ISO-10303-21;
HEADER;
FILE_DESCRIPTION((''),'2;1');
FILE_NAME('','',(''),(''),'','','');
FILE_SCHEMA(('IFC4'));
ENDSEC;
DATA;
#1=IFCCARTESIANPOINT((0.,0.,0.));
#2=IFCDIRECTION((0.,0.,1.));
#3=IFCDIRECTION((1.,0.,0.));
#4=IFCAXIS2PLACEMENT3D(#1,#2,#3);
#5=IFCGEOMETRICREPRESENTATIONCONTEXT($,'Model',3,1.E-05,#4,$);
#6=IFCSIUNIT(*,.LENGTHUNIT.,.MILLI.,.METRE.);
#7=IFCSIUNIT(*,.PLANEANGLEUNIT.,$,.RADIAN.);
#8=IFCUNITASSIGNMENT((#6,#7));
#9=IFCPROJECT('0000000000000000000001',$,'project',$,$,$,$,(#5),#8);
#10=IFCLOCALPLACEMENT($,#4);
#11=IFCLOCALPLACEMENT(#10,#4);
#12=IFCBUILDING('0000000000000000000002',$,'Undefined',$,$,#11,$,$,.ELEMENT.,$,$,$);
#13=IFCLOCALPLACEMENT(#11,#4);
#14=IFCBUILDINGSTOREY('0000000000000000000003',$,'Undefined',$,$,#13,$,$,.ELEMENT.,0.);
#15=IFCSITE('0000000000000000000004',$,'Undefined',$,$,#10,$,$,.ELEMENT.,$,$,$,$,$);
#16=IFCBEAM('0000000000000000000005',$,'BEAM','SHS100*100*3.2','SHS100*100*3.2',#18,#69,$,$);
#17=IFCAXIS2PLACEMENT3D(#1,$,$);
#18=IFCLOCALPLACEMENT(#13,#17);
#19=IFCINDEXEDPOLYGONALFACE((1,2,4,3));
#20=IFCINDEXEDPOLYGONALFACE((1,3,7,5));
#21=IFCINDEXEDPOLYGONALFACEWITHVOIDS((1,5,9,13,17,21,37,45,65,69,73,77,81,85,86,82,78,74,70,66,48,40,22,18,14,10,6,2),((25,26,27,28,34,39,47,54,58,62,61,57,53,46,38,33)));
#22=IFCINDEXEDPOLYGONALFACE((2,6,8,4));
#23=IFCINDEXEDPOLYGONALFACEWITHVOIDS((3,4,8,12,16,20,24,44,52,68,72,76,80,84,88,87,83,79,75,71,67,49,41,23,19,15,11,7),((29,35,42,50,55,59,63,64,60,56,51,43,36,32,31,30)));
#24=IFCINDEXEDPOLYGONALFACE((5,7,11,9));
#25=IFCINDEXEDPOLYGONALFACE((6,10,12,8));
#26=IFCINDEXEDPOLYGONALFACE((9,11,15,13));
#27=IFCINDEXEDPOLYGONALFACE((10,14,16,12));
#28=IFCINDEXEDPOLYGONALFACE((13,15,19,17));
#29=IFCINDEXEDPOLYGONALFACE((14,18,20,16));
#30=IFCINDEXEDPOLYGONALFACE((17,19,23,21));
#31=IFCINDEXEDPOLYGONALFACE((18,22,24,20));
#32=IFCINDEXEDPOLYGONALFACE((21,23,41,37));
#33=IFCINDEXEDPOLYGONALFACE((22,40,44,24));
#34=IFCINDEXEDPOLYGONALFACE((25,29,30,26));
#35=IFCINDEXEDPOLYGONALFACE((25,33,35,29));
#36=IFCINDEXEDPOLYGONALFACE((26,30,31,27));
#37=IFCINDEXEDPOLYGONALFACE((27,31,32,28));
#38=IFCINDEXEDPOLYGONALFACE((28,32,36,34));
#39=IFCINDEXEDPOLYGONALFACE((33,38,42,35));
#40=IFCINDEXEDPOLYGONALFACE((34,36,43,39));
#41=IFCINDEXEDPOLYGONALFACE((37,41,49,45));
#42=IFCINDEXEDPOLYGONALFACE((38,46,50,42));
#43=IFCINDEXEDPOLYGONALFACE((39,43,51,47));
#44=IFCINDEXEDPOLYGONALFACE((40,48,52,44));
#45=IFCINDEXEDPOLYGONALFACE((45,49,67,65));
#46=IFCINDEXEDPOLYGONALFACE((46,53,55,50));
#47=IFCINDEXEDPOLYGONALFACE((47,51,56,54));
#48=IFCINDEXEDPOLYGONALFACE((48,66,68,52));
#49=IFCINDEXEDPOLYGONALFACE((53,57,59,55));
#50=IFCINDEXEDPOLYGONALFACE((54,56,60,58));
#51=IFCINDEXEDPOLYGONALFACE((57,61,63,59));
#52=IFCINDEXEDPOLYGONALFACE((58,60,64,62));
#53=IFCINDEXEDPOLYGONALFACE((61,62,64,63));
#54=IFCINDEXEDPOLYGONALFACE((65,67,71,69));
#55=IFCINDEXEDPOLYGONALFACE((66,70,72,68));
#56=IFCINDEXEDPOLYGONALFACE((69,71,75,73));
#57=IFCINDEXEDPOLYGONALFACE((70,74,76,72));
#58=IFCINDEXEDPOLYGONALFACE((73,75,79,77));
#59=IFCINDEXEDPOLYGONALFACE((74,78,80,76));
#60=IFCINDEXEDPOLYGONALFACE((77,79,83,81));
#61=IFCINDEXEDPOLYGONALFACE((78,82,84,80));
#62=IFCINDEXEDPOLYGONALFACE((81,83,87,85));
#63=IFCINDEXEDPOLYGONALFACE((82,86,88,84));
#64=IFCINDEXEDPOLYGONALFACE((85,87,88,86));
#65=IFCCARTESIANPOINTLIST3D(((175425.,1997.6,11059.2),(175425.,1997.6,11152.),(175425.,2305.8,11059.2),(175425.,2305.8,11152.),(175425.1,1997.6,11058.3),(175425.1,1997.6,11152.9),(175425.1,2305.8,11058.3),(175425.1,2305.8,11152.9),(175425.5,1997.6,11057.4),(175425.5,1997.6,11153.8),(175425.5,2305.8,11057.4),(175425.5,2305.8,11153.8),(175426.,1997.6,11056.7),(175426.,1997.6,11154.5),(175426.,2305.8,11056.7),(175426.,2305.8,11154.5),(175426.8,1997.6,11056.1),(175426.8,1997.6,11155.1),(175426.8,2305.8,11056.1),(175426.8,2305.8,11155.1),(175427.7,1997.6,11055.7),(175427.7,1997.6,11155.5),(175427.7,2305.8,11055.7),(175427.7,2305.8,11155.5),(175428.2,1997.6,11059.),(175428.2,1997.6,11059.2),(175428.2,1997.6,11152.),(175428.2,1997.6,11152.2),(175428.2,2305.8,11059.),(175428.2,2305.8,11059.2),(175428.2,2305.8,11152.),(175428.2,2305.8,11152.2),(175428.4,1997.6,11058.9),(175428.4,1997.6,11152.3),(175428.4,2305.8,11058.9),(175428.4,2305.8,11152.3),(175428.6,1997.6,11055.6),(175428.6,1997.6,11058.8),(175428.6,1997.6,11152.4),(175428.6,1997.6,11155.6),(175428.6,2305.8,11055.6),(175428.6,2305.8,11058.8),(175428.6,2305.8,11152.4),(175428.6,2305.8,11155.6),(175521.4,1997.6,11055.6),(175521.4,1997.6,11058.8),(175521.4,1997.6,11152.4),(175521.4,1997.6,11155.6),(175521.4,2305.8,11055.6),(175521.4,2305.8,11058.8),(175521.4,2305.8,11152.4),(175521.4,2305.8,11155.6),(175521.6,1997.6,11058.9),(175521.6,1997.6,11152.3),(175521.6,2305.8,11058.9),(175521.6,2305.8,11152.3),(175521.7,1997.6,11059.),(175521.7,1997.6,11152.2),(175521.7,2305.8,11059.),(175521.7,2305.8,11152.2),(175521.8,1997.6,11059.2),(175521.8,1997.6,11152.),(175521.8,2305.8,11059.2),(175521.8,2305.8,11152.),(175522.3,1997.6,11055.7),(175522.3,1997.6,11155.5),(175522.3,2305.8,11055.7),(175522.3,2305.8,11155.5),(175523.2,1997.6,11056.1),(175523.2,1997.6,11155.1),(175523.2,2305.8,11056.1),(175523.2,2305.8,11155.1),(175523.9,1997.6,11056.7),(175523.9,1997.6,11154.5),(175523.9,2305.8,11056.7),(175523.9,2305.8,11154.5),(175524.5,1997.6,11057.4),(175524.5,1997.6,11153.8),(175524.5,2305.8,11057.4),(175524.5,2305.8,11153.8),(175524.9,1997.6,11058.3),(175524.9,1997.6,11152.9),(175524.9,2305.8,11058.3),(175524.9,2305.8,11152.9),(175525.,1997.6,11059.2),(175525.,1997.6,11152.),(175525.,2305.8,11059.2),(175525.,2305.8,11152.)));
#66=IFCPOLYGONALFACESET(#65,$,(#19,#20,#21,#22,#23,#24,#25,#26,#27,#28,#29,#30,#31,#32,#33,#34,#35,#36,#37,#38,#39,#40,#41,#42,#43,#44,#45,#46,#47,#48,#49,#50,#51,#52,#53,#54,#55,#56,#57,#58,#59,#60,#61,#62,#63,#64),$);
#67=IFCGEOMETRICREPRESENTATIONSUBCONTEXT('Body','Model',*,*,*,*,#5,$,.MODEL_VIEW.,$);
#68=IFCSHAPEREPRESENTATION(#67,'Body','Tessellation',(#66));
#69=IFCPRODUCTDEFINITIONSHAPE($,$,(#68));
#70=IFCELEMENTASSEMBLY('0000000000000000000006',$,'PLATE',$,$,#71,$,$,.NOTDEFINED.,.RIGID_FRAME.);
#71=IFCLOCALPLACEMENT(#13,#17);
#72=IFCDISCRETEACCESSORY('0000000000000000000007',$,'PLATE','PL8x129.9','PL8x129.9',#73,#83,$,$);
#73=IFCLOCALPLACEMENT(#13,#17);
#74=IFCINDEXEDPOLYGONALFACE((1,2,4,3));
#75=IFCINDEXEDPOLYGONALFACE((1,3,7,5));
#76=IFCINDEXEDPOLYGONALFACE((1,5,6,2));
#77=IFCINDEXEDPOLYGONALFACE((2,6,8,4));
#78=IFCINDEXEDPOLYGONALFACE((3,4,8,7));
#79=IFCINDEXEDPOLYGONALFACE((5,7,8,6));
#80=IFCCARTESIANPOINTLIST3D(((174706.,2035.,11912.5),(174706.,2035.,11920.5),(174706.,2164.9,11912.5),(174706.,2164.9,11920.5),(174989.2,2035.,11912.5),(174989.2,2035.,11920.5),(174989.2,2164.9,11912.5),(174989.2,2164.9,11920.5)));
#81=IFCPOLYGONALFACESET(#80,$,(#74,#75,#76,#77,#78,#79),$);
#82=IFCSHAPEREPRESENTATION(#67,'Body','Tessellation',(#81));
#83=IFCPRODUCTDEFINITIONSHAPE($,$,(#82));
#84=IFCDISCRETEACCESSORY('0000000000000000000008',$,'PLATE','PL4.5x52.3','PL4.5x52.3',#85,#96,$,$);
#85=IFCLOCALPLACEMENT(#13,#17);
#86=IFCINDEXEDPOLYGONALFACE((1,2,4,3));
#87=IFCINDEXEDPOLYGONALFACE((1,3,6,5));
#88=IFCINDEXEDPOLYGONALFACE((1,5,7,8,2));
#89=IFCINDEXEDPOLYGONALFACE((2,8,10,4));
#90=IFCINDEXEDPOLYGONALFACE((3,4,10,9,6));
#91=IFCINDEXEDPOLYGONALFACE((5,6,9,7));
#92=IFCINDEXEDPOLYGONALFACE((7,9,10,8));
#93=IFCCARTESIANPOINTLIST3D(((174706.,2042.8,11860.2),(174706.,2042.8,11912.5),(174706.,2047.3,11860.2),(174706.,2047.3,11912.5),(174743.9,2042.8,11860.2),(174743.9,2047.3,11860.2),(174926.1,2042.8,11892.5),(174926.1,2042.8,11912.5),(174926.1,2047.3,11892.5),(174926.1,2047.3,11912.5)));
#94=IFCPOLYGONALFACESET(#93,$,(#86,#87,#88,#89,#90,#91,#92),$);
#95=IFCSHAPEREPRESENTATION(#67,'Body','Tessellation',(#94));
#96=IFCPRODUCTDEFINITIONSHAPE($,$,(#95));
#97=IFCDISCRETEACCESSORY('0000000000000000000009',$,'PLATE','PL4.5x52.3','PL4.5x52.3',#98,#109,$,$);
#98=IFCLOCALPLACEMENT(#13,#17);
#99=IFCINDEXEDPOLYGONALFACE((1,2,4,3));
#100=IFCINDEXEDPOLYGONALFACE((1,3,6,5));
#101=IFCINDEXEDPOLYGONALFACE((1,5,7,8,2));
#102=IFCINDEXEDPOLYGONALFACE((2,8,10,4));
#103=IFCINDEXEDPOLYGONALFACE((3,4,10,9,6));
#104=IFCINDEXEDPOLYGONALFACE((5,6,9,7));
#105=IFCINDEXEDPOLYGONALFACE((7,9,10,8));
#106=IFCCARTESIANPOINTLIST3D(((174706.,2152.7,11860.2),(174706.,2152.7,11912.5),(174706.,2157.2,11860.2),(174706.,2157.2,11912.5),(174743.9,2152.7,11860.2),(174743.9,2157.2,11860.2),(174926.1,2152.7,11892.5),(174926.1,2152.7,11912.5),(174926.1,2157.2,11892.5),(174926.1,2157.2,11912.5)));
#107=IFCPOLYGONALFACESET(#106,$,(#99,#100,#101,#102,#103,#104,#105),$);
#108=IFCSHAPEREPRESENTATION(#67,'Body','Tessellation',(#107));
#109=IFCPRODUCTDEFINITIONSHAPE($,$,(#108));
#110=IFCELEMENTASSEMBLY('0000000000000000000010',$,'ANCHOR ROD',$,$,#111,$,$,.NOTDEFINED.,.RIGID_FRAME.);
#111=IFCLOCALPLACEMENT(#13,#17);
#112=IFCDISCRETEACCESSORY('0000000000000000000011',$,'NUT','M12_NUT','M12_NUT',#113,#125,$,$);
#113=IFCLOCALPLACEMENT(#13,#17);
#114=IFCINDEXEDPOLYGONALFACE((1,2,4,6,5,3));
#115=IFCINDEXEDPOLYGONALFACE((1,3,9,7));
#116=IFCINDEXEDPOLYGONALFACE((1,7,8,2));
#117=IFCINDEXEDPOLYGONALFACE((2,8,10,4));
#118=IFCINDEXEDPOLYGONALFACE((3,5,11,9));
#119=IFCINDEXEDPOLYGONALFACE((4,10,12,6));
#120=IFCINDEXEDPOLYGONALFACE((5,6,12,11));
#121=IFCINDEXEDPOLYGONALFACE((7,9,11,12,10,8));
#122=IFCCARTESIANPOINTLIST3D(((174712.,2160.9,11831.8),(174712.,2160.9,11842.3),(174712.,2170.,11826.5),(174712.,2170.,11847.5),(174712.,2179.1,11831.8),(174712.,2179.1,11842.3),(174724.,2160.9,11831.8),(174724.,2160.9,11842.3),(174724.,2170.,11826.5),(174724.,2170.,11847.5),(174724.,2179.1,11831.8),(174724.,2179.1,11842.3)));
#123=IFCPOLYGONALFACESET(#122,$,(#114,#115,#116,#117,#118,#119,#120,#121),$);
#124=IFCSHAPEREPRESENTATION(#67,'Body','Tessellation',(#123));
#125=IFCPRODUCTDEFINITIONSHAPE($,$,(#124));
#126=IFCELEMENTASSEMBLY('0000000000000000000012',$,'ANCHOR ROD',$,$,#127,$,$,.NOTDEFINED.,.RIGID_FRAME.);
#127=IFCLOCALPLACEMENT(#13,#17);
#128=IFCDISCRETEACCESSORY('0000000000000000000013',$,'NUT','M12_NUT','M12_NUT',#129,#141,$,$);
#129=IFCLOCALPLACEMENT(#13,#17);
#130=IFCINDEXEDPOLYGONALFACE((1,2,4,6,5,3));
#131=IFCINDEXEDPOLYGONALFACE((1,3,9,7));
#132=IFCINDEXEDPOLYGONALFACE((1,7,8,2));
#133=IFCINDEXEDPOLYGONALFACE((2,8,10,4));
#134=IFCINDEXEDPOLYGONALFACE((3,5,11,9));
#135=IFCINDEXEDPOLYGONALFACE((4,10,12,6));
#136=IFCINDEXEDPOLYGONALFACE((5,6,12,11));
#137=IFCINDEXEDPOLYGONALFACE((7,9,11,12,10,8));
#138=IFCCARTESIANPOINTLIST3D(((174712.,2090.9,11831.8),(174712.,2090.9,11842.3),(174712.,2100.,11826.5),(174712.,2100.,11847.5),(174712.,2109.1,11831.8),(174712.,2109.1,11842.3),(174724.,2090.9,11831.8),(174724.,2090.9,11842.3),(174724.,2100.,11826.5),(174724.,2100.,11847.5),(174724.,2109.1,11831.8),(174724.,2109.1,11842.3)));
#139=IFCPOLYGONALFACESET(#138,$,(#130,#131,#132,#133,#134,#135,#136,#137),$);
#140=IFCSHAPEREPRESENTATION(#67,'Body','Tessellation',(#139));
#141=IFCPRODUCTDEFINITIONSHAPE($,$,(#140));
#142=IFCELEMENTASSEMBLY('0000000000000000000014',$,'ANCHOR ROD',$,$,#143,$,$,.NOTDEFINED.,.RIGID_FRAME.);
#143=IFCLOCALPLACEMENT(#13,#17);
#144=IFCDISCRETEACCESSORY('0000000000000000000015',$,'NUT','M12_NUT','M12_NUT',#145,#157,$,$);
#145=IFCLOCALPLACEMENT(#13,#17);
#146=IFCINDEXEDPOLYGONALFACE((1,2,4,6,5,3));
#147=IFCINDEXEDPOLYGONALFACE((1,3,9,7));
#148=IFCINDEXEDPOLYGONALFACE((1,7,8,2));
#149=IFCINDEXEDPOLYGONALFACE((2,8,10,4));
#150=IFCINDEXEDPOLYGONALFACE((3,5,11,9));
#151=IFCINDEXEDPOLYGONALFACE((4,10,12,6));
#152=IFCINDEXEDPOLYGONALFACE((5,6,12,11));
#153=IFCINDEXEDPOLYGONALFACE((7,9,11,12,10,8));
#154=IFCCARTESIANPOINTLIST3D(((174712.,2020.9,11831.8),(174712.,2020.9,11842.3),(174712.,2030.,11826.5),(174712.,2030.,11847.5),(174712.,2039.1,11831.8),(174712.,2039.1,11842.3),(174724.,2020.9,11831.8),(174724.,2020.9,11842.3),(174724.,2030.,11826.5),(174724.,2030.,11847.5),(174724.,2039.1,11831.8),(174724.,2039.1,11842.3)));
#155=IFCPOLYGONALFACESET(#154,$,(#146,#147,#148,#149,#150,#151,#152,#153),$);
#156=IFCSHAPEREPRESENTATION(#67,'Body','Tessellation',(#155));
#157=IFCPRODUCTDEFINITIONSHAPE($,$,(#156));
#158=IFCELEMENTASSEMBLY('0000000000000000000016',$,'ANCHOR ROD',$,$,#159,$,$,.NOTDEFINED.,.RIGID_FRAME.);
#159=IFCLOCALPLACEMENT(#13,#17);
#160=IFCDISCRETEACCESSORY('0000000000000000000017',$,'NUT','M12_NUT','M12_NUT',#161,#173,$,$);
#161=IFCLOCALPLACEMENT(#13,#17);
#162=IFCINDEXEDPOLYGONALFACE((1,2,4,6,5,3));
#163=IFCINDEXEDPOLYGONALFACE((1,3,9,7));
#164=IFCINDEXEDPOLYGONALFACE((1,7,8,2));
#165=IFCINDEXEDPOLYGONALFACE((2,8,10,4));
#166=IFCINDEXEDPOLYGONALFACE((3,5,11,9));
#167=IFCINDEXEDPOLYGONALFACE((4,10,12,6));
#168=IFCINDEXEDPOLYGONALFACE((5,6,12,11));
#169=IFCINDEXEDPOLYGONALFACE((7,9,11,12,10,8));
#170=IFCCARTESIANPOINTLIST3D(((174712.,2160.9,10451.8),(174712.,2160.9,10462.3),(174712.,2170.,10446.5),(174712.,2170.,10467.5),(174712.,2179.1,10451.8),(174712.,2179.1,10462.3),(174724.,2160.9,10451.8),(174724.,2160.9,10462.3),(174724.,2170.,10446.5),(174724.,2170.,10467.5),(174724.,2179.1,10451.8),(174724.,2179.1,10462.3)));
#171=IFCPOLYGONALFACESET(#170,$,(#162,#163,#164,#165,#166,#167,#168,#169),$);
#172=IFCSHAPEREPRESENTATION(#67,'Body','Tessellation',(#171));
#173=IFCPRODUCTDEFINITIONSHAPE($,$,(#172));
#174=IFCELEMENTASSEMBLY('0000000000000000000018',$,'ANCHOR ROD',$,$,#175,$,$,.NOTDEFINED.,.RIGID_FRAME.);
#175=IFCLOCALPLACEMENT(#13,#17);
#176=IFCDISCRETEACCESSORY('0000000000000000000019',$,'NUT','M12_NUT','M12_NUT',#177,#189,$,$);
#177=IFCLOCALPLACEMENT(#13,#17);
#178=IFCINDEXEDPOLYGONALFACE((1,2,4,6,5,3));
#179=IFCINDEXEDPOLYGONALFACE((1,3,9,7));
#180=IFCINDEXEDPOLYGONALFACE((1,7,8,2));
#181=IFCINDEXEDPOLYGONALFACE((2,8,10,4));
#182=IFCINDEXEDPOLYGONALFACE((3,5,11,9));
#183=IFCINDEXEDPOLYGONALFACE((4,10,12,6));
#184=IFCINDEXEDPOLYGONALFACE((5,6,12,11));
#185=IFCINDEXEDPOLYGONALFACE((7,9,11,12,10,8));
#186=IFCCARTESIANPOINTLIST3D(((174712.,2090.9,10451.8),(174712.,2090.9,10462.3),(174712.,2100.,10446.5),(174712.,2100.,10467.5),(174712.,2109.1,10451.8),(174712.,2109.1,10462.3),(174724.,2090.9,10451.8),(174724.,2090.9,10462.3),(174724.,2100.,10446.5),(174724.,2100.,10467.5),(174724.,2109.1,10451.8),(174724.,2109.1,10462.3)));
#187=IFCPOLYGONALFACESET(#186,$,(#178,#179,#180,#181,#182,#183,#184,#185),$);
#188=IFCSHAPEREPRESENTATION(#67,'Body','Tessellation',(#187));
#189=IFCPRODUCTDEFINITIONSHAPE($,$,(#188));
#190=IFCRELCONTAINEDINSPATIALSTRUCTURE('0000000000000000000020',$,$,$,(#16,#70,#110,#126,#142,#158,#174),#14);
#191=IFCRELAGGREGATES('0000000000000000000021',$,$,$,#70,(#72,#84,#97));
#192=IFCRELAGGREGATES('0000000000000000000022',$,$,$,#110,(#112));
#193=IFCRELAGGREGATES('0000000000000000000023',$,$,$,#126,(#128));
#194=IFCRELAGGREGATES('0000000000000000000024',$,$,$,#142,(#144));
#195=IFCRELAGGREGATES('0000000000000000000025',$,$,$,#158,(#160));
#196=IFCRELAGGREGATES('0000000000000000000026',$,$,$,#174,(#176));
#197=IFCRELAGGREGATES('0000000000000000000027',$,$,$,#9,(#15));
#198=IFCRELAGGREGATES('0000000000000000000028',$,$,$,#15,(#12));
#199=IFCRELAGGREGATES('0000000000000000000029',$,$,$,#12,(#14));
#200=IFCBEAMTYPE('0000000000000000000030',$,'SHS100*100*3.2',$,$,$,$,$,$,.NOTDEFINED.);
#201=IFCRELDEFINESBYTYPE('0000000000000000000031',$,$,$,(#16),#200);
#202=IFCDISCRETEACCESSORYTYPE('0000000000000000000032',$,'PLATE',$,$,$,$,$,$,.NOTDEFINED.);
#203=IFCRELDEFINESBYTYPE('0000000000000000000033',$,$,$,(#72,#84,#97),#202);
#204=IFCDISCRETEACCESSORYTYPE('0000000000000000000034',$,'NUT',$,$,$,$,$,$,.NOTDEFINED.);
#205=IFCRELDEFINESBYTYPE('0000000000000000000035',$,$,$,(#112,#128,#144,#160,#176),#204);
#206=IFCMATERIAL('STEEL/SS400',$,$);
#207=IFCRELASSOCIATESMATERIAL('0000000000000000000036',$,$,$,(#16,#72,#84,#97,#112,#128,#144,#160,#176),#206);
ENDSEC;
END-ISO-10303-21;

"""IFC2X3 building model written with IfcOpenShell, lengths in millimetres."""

from ifc_helpers import new_model, si_unit, frame, origin_with_axes, origin_2d_with_axis, place, context, subcontext, project, spatial, polyline, hollow_rectangle, outline, extrude, material, type_object, element, aggregate, save


model = new_model("IFC2X3")

# Units and contexts
model_context = context("Model", 3, precision=1e-05, world=origin_with_axes())
body_context = subcontext(model_context, "Body", "Model", "MODEL_VIEW")
ifc_project = project(units=[si_unit("LENGTHUNIT", "METRE", prefix="MILLI"), si_unit("PLANEANGLEUNIT", "RADIAN")], contexts=[model_context])

# Site, building, storey
site_placement = place(None, origin_with_axes())
site = spatial("IfcSite", under=ifc_project, at=site_placement, Name="Undefined", CompositionType="ELEMENT")
building_placement = place(site_placement, origin_with_axes())
building = spatial("IfcBuilding", under=site, at=building_placement, Name="Undefined", CompositionType="ELEMENT")
storey_placement = place(building_placement, origin_with_axes())
storey = spatial("IfcBuildingStorey", under=building, at=storey_placement, Name="Undefined", CompositionType="ELEMENT", Elevation=0.0)

# Beam
ifc_material_1 = material(Name="STEEL/SS400")
beam_type = type_object("IfcBeamType", Name="SHS100*100*3.2", PredefinedType="NOTDEFINED")
beam_placement = place(storey_placement, frame((175475.0, 1997.6, 11105.6), z_axis=(1.0, 0.0, 0.0), x_axis=(0.0, 1.0, 0.0)))
element("IfcBeam", 1, at=beam_placement, inside=storey, type_object=beam_type, material=ifc_material_1, Name="BEAM", Description="SHS100*100*3.2", ObjectType="SHS100*100*3.2", context=body_context, shape_type="SweptSolid", body=[
    extrude(hollow_rectangle(XDim=100.0, YDim=100.0, WallThickness=3.2, InnerFilletRadius=0.4, OuterFilletRadius=3.6, at=origin_2d_with_axis()), frame((308.2, 0.0, 0.0), z_axis=(-1.0, 0.0, 0.0), x_axis=(0.0, -1.0, 0.0)), (0.0, 0.0, 1.0), 308.2),
])

# Element assembly, discrete accessories
assembly_1_placement = place(storey_placement, origin_with_axes())
assembly_1 = element("IfcElementAssembly", 2, at=assembly_1_placement, inside=storey, Name="PLATE", AssemblyPlace="NOTDEFINED", PredefinedType="RIGID_FRAME")
discrete_accessory_type_1 = type_object("IfcDiscreteAccessoryType", Name="PLATE")
discrete_accessory_1_placement = place(assembly_1_placement, frame((174989.2, 2035.0, 11916.5), z_axis=(0.0, 0.0, -1.0), x_axis=(-1.0, 0.0, 0.0)))
discrete_accessory_1 = element("IfcDiscreteAccessory", 3, at=discrete_accessory_1_placement, type_object=discrete_accessory_type_1, material=ifc_material_1, Name="PLATE", Description="PL8x129.9", ObjectType="PL8x129.9", context=body_context, shape_type="SweptSolid", body=[
    extrude(outline(polyline([(0.0, 0.0), (283.2, 0.0), (283.2, 129.9), (0.0, 129.9), (0.0, 0.0)])), frame((0.0, 0.0, -4.0), z_axis=(0.0, 0.0, 1.0), x_axis=(1.0, 0.0, 0.0)), (0.0, 0.0, 1.0), 8.0),
])
discrete_accessory_2_placement = place(assembly_1_placement, frame((174926.1, 2045.0, 11912.5), z_axis=(0.0, 1.0, 0.0), x_axis=(0.0, 0.0, -1.0)))
discrete_accessory_2 = element("IfcDiscreteAccessory", 4, at=discrete_accessory_2_placement, type_object=discrete_accessory_type_1, material=ifc_material_1, Name="PLATE", Description="PL4.5x52.3", ObjectType="PL4.5x52.3", context=body_context, shape_type="SweptSolid", body=[
    extrude(outline(polyline([(0.0, 0.0), (20.0, 0.0), (52.3, 182.2), (52.3, 220.1), (0.0, 220.1), (0.0, 0.0)])), frame((0.0, 0.0, -2.2), z_axis=(0.0, 0.0, 1.0), x_axis=(1.0, 0.0, 0.0)), (0.0, 0.0, 1.0), 4.5),
])
discrete_accessory_3_placement = place(assembly_1_placement, frame((174926.1, 2155.0, 11912.5), z_axis=(0.0, 1.0, 0.0), x_axis=(0.0, 0.0, -1.0)))
discrete_accessory_3 = element("IfcDiscreteAccessory", 5, at=discrete_accessory_3_placement, type_object=discrete_accessory_type_1, material=ifc_material_1, Name="PLATE", Description="PL4.5x52.3", ObjectType="PL4.5x52.3", context=body_context, shape_type="SweptSolid", body=[
    extrude(outline(polyline([(0.0, 0.0), (20.0, 0.0), (52.3, 182.2), (52.3, 220.1), (0.0, 220.1), (0.0, 0.0)])), frame((0.0, 0.0, -2.2), z_axis=(0.0, 0.0, 1.0), x_axis=(1.0, 0.0, 0.0)), (0.0, 0.0, 1.0), 4.5),
])
aggregate(assembly_1, [discrete_accessory_1, discrete_accessory_2, discrete_accessory_3])

# Element assemblies, discrete accessories
assembly_2_placement = place(storey_placement, origin_with_axes())
assembly_2 = element("IfcElementAssembly", 6, at=assembly_2_placement, inside=storey, Name="ANCHOR ROD", AssemblyPlace="NOTDEFINED", PredefinedType="RIGID_FRAME")
discrete_accessory_type_2 = type_object("IfcDiscreteAccessoryType", Name="NUT")
discrete_accessory_4_placement = place(assembly_2_placement, frame((174724.0, 2170.0, 11837.0), z_axis=(0.0, -1.0, 0.0), x_axis=(-1.0, 0.0, 0.0)))
discrete_accessory_4 = element("IfcDiscreteAccessory", 7, at=discrete_accessory_4_placement, type_object=discrete_accessory_type_2, material=ifc_material_1, Name="NUT", Description="M12_NUT", ObjectType="M12_NUT", context=body_context, shape_type="SweptSolid", body=[
    extrude(outline(polyline([(-5.2, -9.1), (-10.5, 0.0), (-5.2, 9.1), (5.3, 9.1), (10.5, 0.0), (5.3, -9.1), (-5.2, -9.1)])), frame((12.0, 0.0, 0.0), z_axis=(-1.0, 0.0, 0.0), x_axis=(0.0, -1.0, 0.0)), (0.0, 0.0, 1.0), 12.0),
])
assembly_3_placement = place(storey_placement, origin_with_axes())
assembly_3 = element("IfcElementAssembly", 8, at=assembly_3_placement, inside=storey, Name="ANCHOR ROD", AssemblyPlace="NOTDEFINED", PredefinedType="RIGID_FRAME")
discrete_accessory_5_placement = place(assembly_3_placement, frame((174724.0, 2100.0, 11837.0), z_axis=(0.0, -1.0, 0.0), x_axis=(-1.0, 0.0, 0.0)))
discrete_accessory_5 = element("IfcDiscreteAccessory", 9, at=discrete_accessory_5_placement, type_object=discrete_accessory_type_2, material=ifc_material_1, Name="NUT", Description="M12_NUT", ObjectType="M12_NUT", context=body_context, shape_type="SweptSolid", body=[
    extrude(outline(polyline([(-5.2, -9.1), (-10.5, 0.0), (-5.2, 9.1), (5.3, 9.1), (10.5, 0.0), (5.3, -9.1), (-5.2, -9.1)])), frame((12.0, 0.0, 0.0), z_axis=(-1.0, 0.0, 0.0), x_axis=(0.0, -1.0, 0.0)), (0.0, 0.0, 1.0), 12.0),
])
assembly_4_placement = place(storey_placement, origin_with_axes())
assembly_4 = element("IfcElementAssembly", 10, at=assembly_4_placement, inside=storey, Name="ANCHOR ROD", AssemblyPlace="NOTDEFINED", PredefinedType="RIGID_FRAME")
discrete_accessory_6_placement = place(assembly_4_placement, frame((174724.0, 2030.0, 11837.0), z_axis=(0.0, -1.0, 0.0), x_axis=(-1.0, 0.0, 0.0)))
discrete_accessory_6 = element("IfcDiscreteAccessory", 11, at=discrete_accessory_6_placement, type_object=discrete_accessory_type_2, material=ifc_material_1, Name="NUT", Description="M12_NUT", ObjectType="M12_NUT", context=body_context, shape_type="SweptSolid", body=[
    extrude(outline(polyline([(-5.2, -9.1), (-10.5, 0.0), (-5.2, 9.1), (5.3, 9.1), (10.5, 0.0), (5.3, -9.1), (-5.2, -9.1)])), frame((12.0, 0.0, 0.0), z_axis=(-1.0, 0.0, 0.0), x_axis=(0.0, -1.0, 0.0)), (0.0, 0.0, 1.0), 12.0),
])
assembly_5_placement = place(storey_placement, origin_with_axes())
assembly_5 = element("IfcElementAssembly", 12, at=assembly_5_placement, inside=storey, Name="ANCHOR ROD", AssemblyPlace="NOTDEFINED", PredefinedType="RIGID_FRAME")
discrete_accessory_7_placement = place(assembly_5_placement, frame((174724.0, 2170.0, 10457.0), z_axis=(0.0, 1.0, 0.0), x_axis=(-1.0, 0.0, 0.0)))
discrete_accessory_7 = element("IfcDiscreteAccessory", 13, at=discrete_accessory_7_placement, type_object=discrete_accessory_type_2, material=ifc_material_1, Name="NUT", Description="M12_NUT", ObjectType="M12_NUT", context=body_context, shape_type="SweptSolid", body=[
    extrude(outline(polyline([(-5.2, -9.1), (-10.5, 0.0), (-5.2, 9.1), (5.3, 9.1), (10.5, 0.0), (5.3, -9.1), (-5.2, -9.1)])), frame((12.0, 0.0, 0.0), z_axis=(-1.0, 0.0, 0.0), x_axis=(0.0, -1.0, 0.0)), (0.0, 0.0, 1.0), 12.0),
])
assembly_6_placement = place(storey_placement, origin_with_axes())
assembly_6 = element("IfcElementAssembly", 14, at=assembly_6_placement, inside=storey, Name="ANCHOR ROD", AssemblyPlace="NOTDEFINED", PredefinedType="RIGID_FRAME")
discrete_accessory_8_placement = place(assembly_6_placement, frame((174724.0, 2100.0, 10457.0), z_axis=(0.0, 1.0, 0.0), x_axis=(-1.0, 0.0, 0.0)))
discrete_accessory_8 = element("IfcDiscreteAccessory", 15, at=discrete_accessory_8_placement, type_object=discrete_accessory_type_2, material=ifc_material_1, Name="NUT", Description="M12_NUT", ObjectType="M12_NUT", context=body_context, shape_type="SweptSolid", body=[
    extrude(outline(polyline([(-5.2, -9.1), (-10.5, 0.0), (-5.2, 9.1), (5.3, 9.1), (10.5, 0.0), (5.3, -9.1), (-5.2, -9.1)])), frame((12.0, 0.0, 0.0), z_axis=(-1.0, 0.0, 0.0), x_axis=(0.0, -1.0, 0.0)), (0.0, 0.0, 1.0), 12.0),
])

aggregate(assembly_2, [discrete_accessory_4])

aggregate(assembly_3, [discrete_accessory_5])

aggregate(assembly_4, [discrete_accessory_6])
aggregate(assembly_5, [discrete_accessory_7])
aggregate(assembly_6, [discrete_accessory_8])

save(model, "model.ifc")
